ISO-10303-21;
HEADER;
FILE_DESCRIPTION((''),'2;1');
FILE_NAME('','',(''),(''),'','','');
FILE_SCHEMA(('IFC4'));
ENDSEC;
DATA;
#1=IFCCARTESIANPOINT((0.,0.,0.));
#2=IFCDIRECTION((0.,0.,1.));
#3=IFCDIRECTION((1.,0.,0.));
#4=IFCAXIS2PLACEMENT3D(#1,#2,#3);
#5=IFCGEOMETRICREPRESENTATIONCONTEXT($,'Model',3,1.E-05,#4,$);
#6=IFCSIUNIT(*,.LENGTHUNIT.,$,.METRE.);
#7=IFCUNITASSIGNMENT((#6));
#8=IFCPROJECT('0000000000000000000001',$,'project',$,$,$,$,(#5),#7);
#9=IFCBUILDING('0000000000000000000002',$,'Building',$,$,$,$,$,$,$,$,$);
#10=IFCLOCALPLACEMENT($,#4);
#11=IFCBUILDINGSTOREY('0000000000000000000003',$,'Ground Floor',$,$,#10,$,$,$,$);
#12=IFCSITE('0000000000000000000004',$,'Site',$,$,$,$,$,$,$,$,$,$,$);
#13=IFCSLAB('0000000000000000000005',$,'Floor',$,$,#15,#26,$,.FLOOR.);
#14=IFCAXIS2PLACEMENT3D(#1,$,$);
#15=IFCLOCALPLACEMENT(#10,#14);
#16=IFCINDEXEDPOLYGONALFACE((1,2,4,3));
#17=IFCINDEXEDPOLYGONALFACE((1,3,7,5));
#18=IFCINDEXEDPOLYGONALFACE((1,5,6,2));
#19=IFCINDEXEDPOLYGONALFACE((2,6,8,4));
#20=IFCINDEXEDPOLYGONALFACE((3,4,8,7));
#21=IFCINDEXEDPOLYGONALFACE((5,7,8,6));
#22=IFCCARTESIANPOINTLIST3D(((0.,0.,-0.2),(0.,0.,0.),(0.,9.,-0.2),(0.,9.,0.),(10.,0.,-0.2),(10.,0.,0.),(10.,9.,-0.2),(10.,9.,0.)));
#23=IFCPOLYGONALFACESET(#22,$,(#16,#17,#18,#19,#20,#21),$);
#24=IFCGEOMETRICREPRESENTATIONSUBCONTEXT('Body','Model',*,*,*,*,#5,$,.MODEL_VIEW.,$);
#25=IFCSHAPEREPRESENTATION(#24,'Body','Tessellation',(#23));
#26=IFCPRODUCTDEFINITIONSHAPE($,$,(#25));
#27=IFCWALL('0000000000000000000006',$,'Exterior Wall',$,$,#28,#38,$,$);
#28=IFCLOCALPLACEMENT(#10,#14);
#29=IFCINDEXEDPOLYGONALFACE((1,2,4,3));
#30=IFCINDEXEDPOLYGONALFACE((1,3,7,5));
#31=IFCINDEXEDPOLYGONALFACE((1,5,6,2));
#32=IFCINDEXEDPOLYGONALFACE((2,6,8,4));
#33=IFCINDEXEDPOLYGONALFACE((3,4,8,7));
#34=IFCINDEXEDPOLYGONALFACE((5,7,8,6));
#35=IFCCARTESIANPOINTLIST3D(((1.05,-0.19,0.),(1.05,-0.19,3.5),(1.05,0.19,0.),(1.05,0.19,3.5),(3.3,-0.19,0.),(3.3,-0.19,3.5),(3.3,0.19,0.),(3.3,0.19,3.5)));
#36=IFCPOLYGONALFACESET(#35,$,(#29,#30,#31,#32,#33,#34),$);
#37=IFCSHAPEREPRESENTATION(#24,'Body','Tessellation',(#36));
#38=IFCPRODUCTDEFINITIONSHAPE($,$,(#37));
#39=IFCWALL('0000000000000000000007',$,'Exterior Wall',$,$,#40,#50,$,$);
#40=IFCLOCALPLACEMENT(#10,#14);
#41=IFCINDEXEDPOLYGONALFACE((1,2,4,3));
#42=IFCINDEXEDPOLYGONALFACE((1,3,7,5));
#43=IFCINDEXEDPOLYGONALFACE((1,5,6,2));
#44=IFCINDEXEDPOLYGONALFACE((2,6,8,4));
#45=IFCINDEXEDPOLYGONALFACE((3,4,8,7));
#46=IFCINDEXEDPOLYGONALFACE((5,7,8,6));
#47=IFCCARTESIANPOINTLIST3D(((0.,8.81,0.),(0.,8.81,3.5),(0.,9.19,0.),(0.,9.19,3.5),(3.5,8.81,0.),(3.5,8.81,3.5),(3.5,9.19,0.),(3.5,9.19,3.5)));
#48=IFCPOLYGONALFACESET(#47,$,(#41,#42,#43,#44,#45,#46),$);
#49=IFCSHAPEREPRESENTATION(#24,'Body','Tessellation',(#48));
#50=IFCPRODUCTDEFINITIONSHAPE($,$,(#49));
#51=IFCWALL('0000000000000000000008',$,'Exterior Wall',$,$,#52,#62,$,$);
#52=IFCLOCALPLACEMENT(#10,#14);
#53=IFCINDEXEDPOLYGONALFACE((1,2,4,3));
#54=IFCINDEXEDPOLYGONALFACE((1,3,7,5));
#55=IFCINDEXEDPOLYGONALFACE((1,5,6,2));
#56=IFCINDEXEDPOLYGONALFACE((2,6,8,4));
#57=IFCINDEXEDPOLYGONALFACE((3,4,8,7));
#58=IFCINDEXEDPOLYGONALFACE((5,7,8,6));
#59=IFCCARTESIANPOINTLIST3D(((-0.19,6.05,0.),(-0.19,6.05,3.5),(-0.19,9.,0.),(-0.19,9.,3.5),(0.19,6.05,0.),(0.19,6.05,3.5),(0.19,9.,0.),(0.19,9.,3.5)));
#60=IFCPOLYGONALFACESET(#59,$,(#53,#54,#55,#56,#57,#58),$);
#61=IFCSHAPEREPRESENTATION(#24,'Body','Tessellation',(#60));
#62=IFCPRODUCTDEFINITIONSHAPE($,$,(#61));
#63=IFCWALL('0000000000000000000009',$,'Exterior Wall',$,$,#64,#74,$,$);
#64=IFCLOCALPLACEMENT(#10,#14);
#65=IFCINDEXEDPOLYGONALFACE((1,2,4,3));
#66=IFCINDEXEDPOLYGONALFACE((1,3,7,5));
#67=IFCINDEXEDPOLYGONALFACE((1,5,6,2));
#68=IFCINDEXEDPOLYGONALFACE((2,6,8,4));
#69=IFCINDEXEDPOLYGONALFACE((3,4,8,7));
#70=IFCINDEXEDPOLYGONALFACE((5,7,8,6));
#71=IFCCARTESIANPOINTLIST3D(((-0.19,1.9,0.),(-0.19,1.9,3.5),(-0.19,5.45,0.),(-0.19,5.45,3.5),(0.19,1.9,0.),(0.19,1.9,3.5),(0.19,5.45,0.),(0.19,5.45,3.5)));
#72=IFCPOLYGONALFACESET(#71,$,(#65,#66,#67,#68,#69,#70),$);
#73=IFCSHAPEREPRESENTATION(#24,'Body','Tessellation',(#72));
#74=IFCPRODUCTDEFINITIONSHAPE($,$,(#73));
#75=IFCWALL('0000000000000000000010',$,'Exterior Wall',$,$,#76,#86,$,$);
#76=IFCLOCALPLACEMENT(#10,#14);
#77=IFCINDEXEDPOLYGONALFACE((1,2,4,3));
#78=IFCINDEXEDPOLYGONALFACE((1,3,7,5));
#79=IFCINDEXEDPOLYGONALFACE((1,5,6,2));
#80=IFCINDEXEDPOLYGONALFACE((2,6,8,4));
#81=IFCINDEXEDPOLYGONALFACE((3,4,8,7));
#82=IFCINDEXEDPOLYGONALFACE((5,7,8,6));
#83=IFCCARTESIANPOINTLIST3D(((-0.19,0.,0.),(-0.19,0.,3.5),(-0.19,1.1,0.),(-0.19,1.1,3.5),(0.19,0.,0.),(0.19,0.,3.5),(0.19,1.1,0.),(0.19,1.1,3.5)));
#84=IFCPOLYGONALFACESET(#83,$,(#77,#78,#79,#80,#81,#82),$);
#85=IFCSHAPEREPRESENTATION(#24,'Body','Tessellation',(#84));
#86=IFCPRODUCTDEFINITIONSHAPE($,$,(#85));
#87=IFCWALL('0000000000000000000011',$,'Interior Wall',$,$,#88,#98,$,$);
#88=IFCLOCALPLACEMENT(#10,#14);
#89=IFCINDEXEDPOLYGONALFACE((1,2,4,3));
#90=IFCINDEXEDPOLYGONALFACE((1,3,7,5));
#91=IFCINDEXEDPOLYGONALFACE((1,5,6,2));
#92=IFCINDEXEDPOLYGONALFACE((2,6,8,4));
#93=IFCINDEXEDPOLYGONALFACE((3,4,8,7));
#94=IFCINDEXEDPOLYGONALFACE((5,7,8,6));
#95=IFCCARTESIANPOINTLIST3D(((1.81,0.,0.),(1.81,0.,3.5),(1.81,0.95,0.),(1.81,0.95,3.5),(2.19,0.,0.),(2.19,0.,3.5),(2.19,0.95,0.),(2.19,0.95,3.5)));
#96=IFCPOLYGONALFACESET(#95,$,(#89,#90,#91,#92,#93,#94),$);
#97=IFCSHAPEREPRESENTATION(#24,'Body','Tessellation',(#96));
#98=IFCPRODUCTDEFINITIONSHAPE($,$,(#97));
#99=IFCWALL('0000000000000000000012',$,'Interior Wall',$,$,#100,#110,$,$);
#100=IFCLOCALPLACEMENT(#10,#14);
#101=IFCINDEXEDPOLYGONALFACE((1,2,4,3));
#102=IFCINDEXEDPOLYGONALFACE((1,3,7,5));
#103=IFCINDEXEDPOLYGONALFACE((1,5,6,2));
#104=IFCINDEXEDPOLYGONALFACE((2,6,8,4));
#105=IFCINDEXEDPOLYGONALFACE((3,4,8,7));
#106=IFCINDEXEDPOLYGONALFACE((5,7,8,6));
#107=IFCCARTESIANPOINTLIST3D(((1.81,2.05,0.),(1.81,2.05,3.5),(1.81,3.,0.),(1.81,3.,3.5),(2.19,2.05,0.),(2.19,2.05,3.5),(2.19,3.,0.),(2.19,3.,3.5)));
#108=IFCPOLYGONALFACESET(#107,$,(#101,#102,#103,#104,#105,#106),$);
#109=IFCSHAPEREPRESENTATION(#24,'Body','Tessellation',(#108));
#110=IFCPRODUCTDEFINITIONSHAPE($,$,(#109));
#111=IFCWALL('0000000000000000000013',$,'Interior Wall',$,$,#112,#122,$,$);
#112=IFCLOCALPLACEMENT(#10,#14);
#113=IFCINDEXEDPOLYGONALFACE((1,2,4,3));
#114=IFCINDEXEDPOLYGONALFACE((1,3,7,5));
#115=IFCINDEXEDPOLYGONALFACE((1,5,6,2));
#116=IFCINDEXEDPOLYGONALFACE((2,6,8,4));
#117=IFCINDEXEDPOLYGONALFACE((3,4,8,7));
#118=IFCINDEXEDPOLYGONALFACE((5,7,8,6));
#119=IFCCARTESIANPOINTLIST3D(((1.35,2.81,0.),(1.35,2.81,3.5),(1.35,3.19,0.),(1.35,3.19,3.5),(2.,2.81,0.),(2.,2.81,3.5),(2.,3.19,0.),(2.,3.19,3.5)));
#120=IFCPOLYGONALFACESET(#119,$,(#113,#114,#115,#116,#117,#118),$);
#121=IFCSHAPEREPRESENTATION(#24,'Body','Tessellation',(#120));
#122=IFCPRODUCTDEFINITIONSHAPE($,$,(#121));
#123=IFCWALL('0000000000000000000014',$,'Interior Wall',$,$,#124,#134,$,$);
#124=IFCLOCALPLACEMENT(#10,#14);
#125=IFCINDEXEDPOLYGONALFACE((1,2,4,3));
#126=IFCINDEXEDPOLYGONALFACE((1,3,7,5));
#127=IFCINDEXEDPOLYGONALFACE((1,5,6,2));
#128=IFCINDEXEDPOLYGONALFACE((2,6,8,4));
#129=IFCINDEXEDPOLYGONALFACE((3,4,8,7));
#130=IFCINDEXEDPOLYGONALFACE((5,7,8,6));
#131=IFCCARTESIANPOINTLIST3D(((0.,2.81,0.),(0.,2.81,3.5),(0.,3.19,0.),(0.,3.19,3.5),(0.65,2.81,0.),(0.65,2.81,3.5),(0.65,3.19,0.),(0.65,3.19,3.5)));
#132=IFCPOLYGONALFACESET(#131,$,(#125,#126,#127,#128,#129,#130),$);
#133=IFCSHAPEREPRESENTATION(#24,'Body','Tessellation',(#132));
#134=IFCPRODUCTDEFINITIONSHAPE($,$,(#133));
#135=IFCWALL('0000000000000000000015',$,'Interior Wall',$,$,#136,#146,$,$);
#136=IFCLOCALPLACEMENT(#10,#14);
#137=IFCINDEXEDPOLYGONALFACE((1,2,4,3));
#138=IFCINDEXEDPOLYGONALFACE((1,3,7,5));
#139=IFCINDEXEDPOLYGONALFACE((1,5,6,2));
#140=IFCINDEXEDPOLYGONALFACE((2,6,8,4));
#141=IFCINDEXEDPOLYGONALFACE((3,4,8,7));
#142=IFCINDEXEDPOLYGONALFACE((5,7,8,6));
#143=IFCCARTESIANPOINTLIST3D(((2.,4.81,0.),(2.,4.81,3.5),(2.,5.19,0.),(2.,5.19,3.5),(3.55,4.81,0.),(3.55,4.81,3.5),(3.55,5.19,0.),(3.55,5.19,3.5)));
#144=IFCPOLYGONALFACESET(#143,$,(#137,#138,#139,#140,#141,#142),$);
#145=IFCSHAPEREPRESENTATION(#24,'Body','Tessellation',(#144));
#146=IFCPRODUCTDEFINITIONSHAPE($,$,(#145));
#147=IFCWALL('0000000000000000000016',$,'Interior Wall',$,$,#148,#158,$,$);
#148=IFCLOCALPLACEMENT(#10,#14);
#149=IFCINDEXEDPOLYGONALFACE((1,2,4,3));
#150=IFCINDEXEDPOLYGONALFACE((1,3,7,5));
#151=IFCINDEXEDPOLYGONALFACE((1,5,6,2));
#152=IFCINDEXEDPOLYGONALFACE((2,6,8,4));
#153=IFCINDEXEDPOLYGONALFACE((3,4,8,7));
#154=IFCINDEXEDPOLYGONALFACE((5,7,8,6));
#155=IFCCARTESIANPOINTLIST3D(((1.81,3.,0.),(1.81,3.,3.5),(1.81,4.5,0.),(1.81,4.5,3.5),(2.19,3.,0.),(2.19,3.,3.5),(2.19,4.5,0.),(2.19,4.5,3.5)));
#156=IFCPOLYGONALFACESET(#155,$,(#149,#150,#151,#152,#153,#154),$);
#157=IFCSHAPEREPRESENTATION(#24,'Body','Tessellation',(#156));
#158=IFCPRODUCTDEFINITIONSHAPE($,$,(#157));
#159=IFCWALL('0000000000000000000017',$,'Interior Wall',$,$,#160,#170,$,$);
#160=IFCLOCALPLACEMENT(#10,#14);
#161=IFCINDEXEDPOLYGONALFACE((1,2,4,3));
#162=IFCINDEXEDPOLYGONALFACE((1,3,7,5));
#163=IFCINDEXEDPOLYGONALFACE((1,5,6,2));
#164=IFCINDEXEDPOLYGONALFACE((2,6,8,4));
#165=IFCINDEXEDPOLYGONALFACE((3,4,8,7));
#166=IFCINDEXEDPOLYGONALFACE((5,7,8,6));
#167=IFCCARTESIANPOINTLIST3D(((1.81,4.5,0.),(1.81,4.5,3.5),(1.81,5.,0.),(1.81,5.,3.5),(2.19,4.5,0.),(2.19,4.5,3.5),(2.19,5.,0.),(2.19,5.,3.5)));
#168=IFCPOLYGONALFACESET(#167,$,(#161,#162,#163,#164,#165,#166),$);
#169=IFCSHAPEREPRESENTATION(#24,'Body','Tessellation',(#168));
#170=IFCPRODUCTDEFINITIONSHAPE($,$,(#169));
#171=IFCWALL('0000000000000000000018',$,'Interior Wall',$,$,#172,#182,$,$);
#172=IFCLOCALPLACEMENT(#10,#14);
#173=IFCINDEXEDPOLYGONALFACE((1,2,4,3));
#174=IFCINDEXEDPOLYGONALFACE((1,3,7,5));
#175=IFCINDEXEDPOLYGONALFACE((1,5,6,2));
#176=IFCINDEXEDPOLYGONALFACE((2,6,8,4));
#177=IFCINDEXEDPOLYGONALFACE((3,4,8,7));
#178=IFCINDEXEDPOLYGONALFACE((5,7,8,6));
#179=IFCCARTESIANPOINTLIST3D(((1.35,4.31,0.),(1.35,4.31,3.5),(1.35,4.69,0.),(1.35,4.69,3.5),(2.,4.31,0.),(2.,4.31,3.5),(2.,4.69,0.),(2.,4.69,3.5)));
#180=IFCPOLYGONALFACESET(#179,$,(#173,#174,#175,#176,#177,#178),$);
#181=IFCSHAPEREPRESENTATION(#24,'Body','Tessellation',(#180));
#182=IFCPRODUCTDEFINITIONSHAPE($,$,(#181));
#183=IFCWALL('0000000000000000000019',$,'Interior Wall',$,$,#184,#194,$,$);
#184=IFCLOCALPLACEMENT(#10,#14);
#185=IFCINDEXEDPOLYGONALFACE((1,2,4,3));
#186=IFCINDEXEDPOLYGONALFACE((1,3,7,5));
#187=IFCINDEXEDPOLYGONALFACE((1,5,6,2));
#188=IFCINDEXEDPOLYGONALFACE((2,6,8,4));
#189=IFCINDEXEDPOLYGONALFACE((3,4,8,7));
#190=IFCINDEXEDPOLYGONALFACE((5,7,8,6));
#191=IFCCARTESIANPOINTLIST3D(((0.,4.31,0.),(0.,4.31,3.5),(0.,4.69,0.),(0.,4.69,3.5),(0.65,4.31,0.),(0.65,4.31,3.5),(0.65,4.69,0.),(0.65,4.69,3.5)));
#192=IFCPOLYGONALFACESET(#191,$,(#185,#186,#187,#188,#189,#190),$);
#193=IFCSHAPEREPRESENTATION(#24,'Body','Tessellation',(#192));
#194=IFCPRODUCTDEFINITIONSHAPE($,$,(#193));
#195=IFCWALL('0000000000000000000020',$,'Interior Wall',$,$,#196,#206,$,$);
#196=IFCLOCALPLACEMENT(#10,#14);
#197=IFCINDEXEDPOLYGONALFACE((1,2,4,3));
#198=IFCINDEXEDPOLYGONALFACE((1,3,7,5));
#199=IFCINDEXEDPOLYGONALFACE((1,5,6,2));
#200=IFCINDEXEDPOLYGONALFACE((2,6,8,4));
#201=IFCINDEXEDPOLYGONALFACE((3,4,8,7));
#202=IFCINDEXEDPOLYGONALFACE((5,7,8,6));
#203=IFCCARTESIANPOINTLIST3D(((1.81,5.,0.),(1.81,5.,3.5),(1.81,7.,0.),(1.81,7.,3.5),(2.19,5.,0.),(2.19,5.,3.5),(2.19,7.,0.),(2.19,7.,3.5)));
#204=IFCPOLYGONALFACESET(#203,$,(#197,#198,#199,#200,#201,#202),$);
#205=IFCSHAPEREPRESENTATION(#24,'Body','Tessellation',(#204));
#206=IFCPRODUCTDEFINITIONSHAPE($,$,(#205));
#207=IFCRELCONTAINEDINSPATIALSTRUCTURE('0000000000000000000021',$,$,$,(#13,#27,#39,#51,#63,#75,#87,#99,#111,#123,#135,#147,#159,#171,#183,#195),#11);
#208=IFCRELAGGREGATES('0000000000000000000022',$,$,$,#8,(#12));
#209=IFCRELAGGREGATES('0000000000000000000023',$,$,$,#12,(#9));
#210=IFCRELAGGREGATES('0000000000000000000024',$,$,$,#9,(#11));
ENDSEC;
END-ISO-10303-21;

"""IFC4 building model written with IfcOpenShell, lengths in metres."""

from ifc_helpers import new_model, si_unit, frame, origin_with_axes, place, context, subcontext, project, spatial, indexed_curve, outline, extrude, element, save


model = new_model("IFC4")

# Units and contexts
model_context = context("Model", 3, precision=1e-05, world=origin_with_axes())
body_context = subcontext(model_context, "Body", "Model", "MODEL_VIEW")
ifc_project = project(units=[si_unit("LENGTHUNIT", "METRE")], contexts=[model_context])

# Site, building, storey
site = spatial("IfcSite", under=ifc_project, Name="Site")
building = spatial("IfcBuilding", under=site, Name="Building")
storey_placement = place(None, origin_with_axes())
storey = spatial("IfcBuildingStorey", under=building, at=storey_placement, Name="Ground Floor")

# Slab
slab_placement = place(storey_placement, frame((0.0, 0.0, -0.2), z_axis=(0.0, 0.0, 1.0), x_axis=(1.0, 0.0, 0.0)))
element("IfcSlab", 1, at=slab_placement, inside=storey, Name="Floor", PredefinedType="FLOOR", context=body_context, shape_type="SweptSolid", body=[
    extrude(outline(indexed_curve([(0.0, 0.0), (10.0, 0.0), (10.0, 9.0), (0.0, 9.0)])), None, (0.0, 0.0, 1.0), 0.2),
])

# Walls
wall_1_placement = place(storey_placement, frame((1.05, 0.0, 0.0), z_axis=(0.0, 0.0, 1.0), x_axis=(1.0, 0.0, 0.0)))
element("IfcWall", 2, at=wall_1_placement, inside=storey, Name="Exterior Wall", context=body_context, shape_type="SweptSolid", body=[
    extrude(outline(indexed_curve([(0.0, 0.0), (0.0, 0.38), (2.25, 0.38), (2.25, 0.0), (0.0, 0.0)], self_intersect=False)), frame((0.0, -0.19, 0.0), z_axis=(0.0, 0.0, 1.0), x_axis=(1.0, 0.0, 0.0)), (0.0, 0.0, 1.0), 3.5),
])
wall_2_placement = place(storey_placement, frame((3.5, 9.0, 0.0), z_axis=(0.0, 0.0, 1.0), x_axis=(-1.0, 0.0, 0.0)))
element("IfcWall", 3, at=wall_2_placement, inside=storey, Name="Exterior Wall", context=body_context, shape_type="SweptSolid", body=[
    extrude(outline(indexed_curve([(0.0, 0.0), (0.0, 0.38), (3.5, 0.38), (3.5, 0.0), (0.0, 0.0)], self_intersect=False)), frame((0.0, -0.19, 0.0), z_axis=(0.0, 0.0, 1.0), x_axis=(1.0, 0.0, 0.0)), (0.0, 0.0, 1.0), 3.5),
])
wall_3_placement = place(storey_placement, frame((0.0, 9.0, 0.0), z_axis=(0.0, 0.0, 1.0), x_axis=(0.0, -1.0, 0.0)))
element("IfcWall", 4, at=wall_3_placement, inside=storey, Name="Exterior Wall", context=body_context, shape_type="SweptSolid", body=[
    extrude(outline(indexed_curve([(0.0, 0.0), (0.0, 0.38), (2.95, 0.38), (2.95, 0.0), (0.0, 0.0)], self_intersect=False)), frame((0.0, -0.19, 0.0), z_axis=(0.0, 0.0, 1.0), x_axis=(1.0, 0.0, 0.0)), (0.0, 0.0, 1.0), 3.5),
])
wall_4_placement = place(storey_placement, frame((0.0, 5.45, 0.0), z_axis=(0.0, 0.0, 1.0), x_axis=(0.0, -1.0, 0.0)))
element("IfcWall", 5, at=wall_4_placement, inside=storey, Name="Exterior Wall", context=body_context, shape_type="SweptSolid", body=[
    extrude(outline(indexed_curve([(0.0, 0.0), (0.0, 0.38), (3.55, 0.38), (3.55, 0.0), (0.0, 0.0)], self_intersect=False)), frame((0.0, -0.19, 0.0), z_axis=(0.0, 0.0, 1.0), x_axis=(1.0, 0.0, 0.0)), (0.0, 0.0, 1.0), 3.5),
])
wall_5_placement = place(storey_placement, frame((0.0, 1.1, 0.0), z_axis=(0.0, 0.0, 1.0), x_axis=(0.0, -1.0, 0.0)))
element("IfcWall", 6, at=wall_5_placement, inside=storey, Name="Exterior Wall", context=body_context, shape_type="SweptSolid", body=[
    extrude(outline(indexed_curve([(0.0, 0.0), (0.0, 0.38), (1.1, 0.38), (1.1, 0.0), (0.0, 0.0)], self_intersect=False)), frame((0.0, -0.19, 0.0), z_axis=(0.0, 0.0, 1.0), x_axis=(1.0, 0.0, 0.0)), (0.0, 0.0, 1.0), 3.5),
])
wall_6_placement = place(storey_placement, frame((2.0, 0.0, 0.0), z_axis=(0.0, 0.0, 1.0), x_axis=(0.0, 1.0, 0.0)))
element("IfcWall", 7, at=wall_6_placement, inside=storey, Name="Interior Wall", context=body_context, shape_type="SweptSolid", body=[
    extrude(outline(indexed_curve([(0.0, 0.0), (0.0, 0.38), (0.95, 0.38), (0.95, 0.0), (0.0, 0.0)], self_intersect=False)), frame((0.0, -0.19, 0.0), z_axis=(0.0, 0.0, 1.0), x_axis=(1.0, 0.0, 0.0)), (0.0, 0.0, 1.0), 3.5),
])
wall_7_placement = place(storey_placement, frame((2.0, 2.05, 0.0), z_axis=(0.0, 0.0, 1.0), x_axis=(0.0, 1.0, 0.0)))
element("IfcWall", 8, at=wall_7_placement, inside=storey, Name="Interior Wall", context=body_context, shape_type="SweptSolid", body=[
    extrude(outline(indexed_curve([(0.0, 0.0), (0.0, 0.38), (0.95, 0.38), (0.95, 0.0), (0.0, 0.0)], self_intersect=False)), frame((0.0, -0.19, 0.0), z_axis=(0.0, 0.0, 1.0), x_axis=(1.0, 0.0, 0.0)), (0.0, 0.0, 1.0), 3.5),
])
for number, where, z_axis, x_axis, name in (
    (9, (2.0, 3.0, 0.0), (0.0, 0.0, 1.0), (-1.0, 0.0, 0.0), "Interior Wall"),
    (10, (0.65, 3.0, 0.0), (0.0, 0.0, 1.0), (-1.0, 0.0, 0.0), "Interior Wall"),
):
    element("IfcWall", number, at=place(storey_placement, frame(where, z_axis=z_axis, x_axis=x_axis)), inside=storey, Name=name, context=body_context, shape_type="SweptSolid", body=[
        extrude(outline(indexed_curve([(0.0, 0.0), (0.0, 0.38), (0.65, 0.38), (0.65, 0.0), (0.0, 0.0)], self_intersect=False)), frame((0.0, -0.19, 0.0), z_axis=(0.0, 0.0, 1.0), x_axis=(1.0, 0.0, 0.0)), (0.0, 0.0, 1.0), 3.5),
    ])
wall_8_placement = place(storey_placement, frame((3.55, 5.0, 0.0), z_axis=(0.0, 0.0, 1.0), x_axis=(-1.0, 0.0, 0.0)))
element("IfcWall", 11, at=wall_8_placement, inside=storey, Name="Interior Wall", context=body_context, shape_type="SweptSolid", body=[
    extrude(outline(indexed_curve([(0.0, 0.0), (0.0, 0.38), (1.55, 0.38), (1.55, 0.0), (0.0, 0.0)], self_intersect=False)), frame((0.0, -0.19, 0.0), z_axis=(0.0, 0.0, 1.0), x_axis=(1.0, 0.0, 0.0)), (0.0, 0.0, 1.0), 3.5),
])
wall_9_placement = place(storey_placement, frame((2.0, 4.5, 0.0), z_axis=(0.0, 0.0, 1.0), x_axis=(0.0, -1.0, 0.0)))
element("IfcWall", 12, at=wall_9_placement, inside=storey, Name="Interior Wall", context=body_context, shape_type="SweptSolid", body=[
    extrude(outline(indexed_curve([(0.0, 0.0), (0.0, 0.38), (1.5, 0.38), (1.5, 0.0), (0.0, 0.0)], self_intersect=False)), frame((0.0, -0.19, 0.0), z_axis=(0.0, 0.0, 1.0), x_axis=(1.0, 0.0, 0.0)), (0.0, 0.0, 1.0), 3.5),
])
wall_10_placement = place(storey_placement, frame((2.0, 5.0, 0.0), z_axis=(0.0, 0.0, 1.0), x_axis=(0.0, -1.0, 0.0)))
element("IfcWall", 13, at=wall_10_placement, inside=storey, Name="Interior Wall", context=body_context, shape_type="SweptSolid", body=[
    extrude(outline(indexed_curve([(0.0, 0.0), (0.0, 0.38), (0.5, 0.38), (0.5, 0.0), (0.0, 0.0)], self_intersect=False)), frame((0.0, -0.19, 0.0), z_axis=(0.0, 0.0, 1.0), x_axis=(1.0, 0.0, 0.0)), (0.0, 0.0, 1.0), 3.5),
])
for number, where, z_axis, x_axis, name in (
    (14, (2.0, 4.5, 0.0), (0.0, 0.0, 1.0), (-1.0, 0.0, 0.0), "Interior Wall"),
    (15, (0.65, 4.5, 0.0), (0.0, 0.0, 1.0), (-1.0, 0.0, 0.0), "Interior Wall"),
):
    element("IfcWall", number, at=place(storey_placement, frame(where, z_axis=z_axis, x_axis=x_axis)), inside=storey, Name=name, context=body_context, shape_type="SweptSolid", body=[
        extrude(outline(indexed_curve([(0.0, 0.0), (0.0, 0.38), (0.65, 0.38), (0.65, 0.0), (0.0, 0.0)], self_intersect=False)), frame((0.0, -0.19, 0.0), z_axis=(0.0, 0.0, 1.0), x_axis=(1.0, 0.0, 0.0)), (0.0, 0.0, 1.0), 3.5),
    ])
wall_11_placement = place(storey_placement, frame((2.0, 5.0, 0.0), z_axis=(0.0, 0.0, 1.0), x_axis=(0.0, 1.0, 0.0)))
element("IfcWall", 16, at=wall_11_placement, inside=storey, Name="Interior Wall", context=body_context, shape_type="SweptSolid", body=[
    extrude(outline(indexed_curve([(0.0, 0.0), (0.0, 0.38), (2.0, 0.38), (2.0, 0.0), (0.0, 0.0)], self_intersect=False)), frame((0.0, -0.19, 0.0), z_axis=(0.0, 0.0, 1.0), x_axis=(1.0, 0.0, 0.0)), (0.0, 0.0, 1.0), 3.5),
])

save(model, "model.ifc")
